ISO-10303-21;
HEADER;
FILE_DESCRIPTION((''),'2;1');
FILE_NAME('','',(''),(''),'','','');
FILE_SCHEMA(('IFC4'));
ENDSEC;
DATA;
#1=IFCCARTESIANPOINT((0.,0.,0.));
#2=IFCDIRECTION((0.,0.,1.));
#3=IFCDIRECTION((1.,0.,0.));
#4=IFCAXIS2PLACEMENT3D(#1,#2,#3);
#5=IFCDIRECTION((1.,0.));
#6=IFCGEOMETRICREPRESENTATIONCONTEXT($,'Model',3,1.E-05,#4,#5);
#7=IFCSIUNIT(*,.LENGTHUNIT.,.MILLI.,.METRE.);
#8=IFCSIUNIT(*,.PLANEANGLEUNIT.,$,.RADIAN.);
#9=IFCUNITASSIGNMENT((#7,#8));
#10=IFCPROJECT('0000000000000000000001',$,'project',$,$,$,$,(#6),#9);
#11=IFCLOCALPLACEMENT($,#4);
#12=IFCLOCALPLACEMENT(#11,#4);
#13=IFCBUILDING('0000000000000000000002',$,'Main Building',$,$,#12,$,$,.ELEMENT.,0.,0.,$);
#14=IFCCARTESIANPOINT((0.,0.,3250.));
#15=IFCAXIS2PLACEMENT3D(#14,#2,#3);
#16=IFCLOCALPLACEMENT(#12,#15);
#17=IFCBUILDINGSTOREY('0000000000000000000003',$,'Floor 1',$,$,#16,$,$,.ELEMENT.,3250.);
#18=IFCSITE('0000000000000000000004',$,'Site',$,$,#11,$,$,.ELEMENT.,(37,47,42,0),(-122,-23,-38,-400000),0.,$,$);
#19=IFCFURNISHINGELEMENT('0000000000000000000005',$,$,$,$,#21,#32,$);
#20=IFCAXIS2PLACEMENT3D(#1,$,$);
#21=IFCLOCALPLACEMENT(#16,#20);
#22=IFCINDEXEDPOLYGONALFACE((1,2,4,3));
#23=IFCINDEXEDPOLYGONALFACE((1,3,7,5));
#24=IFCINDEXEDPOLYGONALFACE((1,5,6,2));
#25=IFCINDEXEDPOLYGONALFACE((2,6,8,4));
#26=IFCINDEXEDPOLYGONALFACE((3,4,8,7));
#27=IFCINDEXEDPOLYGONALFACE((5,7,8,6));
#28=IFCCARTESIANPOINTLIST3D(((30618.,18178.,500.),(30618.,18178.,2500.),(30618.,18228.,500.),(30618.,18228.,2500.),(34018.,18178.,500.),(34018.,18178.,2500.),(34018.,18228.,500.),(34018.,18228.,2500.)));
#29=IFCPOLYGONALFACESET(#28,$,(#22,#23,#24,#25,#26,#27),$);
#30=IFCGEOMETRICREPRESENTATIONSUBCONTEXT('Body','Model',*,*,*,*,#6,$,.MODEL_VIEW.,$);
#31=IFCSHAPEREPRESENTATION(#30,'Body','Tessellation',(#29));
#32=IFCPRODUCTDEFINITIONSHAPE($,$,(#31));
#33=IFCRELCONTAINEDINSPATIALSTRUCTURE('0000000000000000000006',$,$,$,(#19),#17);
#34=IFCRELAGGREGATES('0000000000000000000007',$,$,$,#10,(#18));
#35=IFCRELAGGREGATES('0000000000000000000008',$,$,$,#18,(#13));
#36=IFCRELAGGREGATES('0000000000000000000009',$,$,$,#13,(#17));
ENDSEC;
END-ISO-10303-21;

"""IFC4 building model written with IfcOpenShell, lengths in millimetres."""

from ifc_helpers import new_model, si_unit, direction, frame, origin_with_axes, origin_2d_with_axis, place, context, subcontext, project, spatial, rectangle, extrude, element, save


model = new_model("IFC4")

# Units and contexts
model_context = context("Model", 3, precision=1e-05, world=origin_with_axes(), true_north=direction((1.0, 0.0)))
body_context = subcontext(model_context, "Body", "Model", "MODEL_VIEW")
ifc_project = project(units=[si_unit("LENGTHUNIT", "METRE", prefix="MILLI"), si_unit("PLANEANGLEUNIT", "RADIAN")], contexts=[model_context])

# Site, building, storey
site_placement = place(None, origin_with_axes())
site = spatial("IfcSite", under=ifc_project, at=site_placement, Name="Site", CompositionType="ELEMENT", RefLatitude=(37, 47, 42, 0), RefLongitude=(-122, -23, -38, -400000), RefElevation=0.0)
building_placement = place(site_placement, origin_with_axes())
building = spatial("IfcBuilding", under=site, at=building_placement, Name="Main Building", CompositionType="ELEMENT", ElevationOfRefHeight=0.0, ElevationOfTerrain=0.0)
storey_placement = place(building_placement, frame((0.0, 0.0, 3250.0), z_axis=(0.0, 0.0, 1.0), x_axis=(1.0, 0.0, 0.0)))
storey = spatial("IfcBuildingStorey", under=building, at=storey_placement, Name="Floor 1", CompositionType="ELEMENT", Elevation=3250.0)

# Furnishing element
furnishing_placement = place(storey_placement, frame((30618.0, 18178.0, 500.0), z_axis=(0.0, 0.0, 1.0), x_axis=(1.0, 0.0, 0.0)))
element("IfcFurnishingElement", 1, at=furnishing_placement, inside=storey, context=body_context, shape_type="SweptSolid", body=[
    extrude(rectangle(XDim=3400.0, YDim=50.0, at=origin_2d_with_axis()), frame((1700.0, 25.0, 0.0), z_axis=(0.0, 0.0, 1.0), x_axis=(1.0, 0.0, 0.0)), (0.0, 0.0, 1.0), 2000.0),
])

save(model, "model.ifc")
